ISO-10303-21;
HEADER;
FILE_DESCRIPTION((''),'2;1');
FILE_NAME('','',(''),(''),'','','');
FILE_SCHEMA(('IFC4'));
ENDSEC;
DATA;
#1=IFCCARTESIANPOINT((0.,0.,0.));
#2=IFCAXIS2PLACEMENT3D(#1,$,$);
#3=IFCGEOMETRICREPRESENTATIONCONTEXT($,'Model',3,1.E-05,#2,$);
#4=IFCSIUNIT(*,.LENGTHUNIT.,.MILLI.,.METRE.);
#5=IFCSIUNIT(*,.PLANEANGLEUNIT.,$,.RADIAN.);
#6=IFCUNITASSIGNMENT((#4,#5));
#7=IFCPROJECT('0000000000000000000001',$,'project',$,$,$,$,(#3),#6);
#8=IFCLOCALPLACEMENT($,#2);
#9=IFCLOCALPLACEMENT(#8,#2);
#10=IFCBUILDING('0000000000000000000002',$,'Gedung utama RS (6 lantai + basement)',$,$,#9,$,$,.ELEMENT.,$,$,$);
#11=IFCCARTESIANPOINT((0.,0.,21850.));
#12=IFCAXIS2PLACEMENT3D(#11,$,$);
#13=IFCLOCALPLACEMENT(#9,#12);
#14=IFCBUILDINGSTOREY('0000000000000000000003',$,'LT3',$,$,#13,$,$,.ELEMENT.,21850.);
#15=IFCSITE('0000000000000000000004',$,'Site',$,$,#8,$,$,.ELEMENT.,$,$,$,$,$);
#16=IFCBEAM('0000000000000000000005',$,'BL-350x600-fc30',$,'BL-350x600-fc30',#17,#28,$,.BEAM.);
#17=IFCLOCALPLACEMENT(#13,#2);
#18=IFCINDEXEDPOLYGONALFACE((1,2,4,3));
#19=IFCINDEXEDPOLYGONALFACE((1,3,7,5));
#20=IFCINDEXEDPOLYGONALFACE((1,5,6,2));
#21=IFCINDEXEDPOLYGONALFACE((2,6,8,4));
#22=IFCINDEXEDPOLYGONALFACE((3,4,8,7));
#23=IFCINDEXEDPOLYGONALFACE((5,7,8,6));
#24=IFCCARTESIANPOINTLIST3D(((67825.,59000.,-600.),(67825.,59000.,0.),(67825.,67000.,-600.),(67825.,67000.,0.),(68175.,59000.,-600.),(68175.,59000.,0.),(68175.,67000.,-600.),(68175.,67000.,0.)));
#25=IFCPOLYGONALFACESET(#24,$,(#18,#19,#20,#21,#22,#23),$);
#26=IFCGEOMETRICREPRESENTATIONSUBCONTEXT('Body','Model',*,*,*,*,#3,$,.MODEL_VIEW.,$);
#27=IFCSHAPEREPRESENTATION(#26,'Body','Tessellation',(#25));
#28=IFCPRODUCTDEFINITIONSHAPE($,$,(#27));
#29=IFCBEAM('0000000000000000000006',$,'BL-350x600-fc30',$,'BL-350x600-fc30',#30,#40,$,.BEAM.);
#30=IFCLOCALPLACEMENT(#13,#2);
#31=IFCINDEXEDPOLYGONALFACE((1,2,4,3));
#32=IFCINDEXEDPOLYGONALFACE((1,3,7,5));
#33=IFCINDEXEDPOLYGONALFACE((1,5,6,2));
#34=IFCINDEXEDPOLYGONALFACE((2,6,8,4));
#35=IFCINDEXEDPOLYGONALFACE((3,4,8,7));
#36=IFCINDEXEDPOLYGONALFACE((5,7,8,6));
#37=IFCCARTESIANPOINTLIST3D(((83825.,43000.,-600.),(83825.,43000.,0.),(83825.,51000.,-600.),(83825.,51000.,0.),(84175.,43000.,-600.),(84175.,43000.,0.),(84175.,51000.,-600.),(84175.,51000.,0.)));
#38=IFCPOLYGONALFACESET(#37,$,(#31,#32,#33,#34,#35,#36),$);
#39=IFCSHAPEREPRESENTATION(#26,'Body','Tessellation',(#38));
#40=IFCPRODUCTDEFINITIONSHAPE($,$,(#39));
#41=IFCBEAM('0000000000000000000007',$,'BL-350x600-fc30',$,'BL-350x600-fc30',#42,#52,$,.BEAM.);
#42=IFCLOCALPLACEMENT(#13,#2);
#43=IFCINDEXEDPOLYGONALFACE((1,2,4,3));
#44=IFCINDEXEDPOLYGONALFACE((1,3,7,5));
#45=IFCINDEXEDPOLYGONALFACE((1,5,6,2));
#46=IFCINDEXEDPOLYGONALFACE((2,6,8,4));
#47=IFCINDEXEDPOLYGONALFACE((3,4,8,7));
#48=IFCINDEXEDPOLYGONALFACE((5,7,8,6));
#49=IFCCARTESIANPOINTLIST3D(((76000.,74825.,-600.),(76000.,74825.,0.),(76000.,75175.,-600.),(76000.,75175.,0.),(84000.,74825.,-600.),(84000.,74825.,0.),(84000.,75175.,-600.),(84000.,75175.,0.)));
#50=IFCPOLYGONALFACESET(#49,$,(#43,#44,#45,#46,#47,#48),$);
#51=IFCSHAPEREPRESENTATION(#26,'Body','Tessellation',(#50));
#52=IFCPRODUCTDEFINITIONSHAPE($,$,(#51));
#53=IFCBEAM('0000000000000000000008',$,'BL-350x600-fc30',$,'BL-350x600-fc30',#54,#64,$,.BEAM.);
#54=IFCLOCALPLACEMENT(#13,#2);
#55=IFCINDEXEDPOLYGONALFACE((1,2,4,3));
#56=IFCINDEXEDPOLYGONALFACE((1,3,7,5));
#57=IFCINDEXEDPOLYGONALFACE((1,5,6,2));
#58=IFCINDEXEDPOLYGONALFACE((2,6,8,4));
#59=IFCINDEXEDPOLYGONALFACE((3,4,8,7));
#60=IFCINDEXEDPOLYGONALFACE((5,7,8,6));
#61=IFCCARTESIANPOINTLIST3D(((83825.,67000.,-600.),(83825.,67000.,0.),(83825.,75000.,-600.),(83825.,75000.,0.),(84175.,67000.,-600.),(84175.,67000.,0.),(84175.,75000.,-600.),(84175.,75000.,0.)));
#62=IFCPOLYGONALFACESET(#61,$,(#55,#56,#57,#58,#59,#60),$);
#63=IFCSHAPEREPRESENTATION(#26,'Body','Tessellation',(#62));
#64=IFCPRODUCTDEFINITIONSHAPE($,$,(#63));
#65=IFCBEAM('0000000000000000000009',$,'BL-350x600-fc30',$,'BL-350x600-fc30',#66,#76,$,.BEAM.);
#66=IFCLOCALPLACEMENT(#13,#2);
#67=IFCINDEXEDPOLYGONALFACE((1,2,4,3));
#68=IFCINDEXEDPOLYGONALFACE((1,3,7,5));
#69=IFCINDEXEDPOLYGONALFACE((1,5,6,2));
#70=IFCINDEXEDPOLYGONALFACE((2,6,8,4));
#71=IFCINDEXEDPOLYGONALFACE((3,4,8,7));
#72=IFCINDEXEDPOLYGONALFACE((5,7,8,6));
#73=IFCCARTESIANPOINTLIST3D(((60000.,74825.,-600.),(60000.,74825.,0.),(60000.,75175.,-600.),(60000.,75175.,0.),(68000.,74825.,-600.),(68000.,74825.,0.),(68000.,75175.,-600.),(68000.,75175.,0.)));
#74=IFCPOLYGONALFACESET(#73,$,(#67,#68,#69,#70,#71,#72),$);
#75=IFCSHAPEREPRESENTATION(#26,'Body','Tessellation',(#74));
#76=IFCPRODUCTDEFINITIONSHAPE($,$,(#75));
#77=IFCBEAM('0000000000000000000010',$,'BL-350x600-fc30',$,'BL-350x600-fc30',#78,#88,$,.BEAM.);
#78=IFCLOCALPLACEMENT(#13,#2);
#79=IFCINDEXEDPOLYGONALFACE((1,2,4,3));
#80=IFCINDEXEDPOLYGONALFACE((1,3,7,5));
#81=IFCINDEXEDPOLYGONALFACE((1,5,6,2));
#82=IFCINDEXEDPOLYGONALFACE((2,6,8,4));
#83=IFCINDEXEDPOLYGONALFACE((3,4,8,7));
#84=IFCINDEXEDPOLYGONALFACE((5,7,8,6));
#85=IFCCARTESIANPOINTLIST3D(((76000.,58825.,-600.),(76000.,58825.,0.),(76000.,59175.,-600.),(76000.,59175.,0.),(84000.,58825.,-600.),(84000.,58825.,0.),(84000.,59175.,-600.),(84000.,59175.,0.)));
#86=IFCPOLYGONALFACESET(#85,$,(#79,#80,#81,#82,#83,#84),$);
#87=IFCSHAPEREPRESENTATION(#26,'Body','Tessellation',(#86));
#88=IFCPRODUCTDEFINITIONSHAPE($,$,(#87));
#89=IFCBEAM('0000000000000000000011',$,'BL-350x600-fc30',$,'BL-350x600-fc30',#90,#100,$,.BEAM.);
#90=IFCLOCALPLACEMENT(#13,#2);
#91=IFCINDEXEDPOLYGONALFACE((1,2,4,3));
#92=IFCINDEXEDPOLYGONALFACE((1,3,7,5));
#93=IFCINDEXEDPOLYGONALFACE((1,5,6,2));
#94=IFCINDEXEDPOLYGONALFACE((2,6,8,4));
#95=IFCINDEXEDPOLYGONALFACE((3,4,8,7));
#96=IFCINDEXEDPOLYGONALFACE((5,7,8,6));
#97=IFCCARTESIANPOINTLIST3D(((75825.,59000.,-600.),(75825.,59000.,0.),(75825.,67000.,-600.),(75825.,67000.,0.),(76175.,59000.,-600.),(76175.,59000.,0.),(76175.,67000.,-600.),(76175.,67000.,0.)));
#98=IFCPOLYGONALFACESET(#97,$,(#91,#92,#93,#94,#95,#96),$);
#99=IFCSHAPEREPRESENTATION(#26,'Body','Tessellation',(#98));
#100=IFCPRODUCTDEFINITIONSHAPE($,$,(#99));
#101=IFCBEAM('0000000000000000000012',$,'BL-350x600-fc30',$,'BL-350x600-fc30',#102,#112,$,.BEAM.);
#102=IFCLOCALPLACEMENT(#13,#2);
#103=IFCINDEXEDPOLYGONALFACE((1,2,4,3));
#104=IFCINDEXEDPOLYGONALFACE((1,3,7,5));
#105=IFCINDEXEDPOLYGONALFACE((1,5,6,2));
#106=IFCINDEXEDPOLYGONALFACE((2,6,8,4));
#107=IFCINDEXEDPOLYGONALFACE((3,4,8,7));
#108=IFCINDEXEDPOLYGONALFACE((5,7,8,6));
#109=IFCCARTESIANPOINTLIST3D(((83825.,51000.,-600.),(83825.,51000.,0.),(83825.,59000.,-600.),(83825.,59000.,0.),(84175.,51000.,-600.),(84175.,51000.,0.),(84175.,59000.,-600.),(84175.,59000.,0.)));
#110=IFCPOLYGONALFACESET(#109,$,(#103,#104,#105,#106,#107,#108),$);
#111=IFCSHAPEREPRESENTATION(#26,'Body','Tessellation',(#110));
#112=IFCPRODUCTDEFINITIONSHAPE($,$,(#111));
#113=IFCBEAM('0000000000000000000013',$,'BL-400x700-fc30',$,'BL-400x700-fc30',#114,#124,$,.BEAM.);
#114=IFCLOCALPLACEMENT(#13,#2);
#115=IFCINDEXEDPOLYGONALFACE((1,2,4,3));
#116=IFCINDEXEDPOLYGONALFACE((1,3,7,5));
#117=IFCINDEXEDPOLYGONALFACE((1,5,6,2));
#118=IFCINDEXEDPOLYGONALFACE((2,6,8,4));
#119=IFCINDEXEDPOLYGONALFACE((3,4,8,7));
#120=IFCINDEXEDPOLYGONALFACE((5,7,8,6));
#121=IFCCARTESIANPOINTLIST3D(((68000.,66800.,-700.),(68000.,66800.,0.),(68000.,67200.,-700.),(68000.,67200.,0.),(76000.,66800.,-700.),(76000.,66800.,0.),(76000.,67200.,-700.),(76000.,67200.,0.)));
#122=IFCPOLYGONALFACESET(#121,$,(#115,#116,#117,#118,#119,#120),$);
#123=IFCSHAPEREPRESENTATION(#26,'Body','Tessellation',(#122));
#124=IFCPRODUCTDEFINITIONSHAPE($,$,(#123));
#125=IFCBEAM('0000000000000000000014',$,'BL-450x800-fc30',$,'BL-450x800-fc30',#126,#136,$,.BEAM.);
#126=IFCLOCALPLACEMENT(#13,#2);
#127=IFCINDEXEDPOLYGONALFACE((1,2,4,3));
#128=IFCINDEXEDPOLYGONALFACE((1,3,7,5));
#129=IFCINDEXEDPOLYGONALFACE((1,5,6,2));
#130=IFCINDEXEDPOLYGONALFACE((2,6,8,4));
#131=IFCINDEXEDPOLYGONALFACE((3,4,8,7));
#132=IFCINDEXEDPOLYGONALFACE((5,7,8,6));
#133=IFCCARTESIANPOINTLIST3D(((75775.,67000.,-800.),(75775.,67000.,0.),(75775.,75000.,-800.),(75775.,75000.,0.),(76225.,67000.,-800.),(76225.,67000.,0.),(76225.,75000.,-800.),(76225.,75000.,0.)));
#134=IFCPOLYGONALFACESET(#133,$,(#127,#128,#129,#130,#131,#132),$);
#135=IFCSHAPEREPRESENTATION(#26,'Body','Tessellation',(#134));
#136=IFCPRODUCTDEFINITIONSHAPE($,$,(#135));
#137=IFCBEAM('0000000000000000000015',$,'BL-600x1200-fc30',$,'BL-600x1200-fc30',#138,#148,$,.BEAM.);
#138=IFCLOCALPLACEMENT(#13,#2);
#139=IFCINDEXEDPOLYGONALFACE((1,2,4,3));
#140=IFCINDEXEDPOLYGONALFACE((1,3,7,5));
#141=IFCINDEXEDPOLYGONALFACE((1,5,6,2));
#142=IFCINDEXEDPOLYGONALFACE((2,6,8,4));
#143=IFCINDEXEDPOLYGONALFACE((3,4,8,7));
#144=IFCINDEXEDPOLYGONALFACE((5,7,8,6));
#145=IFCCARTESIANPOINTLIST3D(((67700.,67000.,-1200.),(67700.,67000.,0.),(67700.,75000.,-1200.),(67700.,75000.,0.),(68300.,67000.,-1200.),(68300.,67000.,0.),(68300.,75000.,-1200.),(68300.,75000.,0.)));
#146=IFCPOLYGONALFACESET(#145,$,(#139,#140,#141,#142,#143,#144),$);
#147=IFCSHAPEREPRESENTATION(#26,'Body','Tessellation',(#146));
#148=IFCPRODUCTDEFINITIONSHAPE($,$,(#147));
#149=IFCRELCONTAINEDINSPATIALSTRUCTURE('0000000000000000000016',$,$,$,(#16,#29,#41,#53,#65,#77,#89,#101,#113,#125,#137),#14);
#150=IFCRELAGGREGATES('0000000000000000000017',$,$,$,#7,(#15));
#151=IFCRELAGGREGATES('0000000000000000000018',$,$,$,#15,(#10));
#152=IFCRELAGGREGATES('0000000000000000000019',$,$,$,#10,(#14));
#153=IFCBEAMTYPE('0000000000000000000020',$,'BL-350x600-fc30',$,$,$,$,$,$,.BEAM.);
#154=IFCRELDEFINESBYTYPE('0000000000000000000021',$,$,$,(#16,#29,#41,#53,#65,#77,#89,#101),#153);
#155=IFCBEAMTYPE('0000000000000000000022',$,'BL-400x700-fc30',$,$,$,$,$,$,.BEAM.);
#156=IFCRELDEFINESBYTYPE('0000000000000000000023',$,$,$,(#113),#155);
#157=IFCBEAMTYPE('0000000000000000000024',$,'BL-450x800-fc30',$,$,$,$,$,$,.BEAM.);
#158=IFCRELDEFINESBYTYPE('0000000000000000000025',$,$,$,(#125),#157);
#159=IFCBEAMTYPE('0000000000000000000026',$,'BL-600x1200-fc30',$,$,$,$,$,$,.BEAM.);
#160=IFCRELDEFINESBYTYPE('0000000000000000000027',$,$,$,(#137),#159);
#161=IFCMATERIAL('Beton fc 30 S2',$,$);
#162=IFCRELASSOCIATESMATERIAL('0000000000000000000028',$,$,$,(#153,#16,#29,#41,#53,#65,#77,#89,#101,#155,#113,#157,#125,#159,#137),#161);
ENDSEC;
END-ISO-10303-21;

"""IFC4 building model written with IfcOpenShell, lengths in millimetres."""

from ifc_helpers import new_model, si_unit, frame, origin, origin_2d, place, context, subcontext, project, spatial, rectangle, extrude, material, material_profile, profile_set, profile_usage, type_object, element, save


model = new_model("IFC4")

# Units and contexts
model_context = context("Model", 3, precision=1e-05, world=origin())
body_context = subcontext(model_context, "Body", "Model", "MODEL_VIEW")
ifc_project = project(units=[si_unit("LENGTHUNIT", "METRE", prefix="MILLI"), si_unit("PLANEANGLEUNIT", "RADIAN")], contexts=[model_context])

# Site, building, storey
site_placement = place(None, origin())
site = spatial("IfcSite", under=ifc_project, at=site_placement, Name="Site", CompositionType="ELEMENT")
building_placement = place(site_placement, origin())
building = spatial("IfcBuilding", under=site, at=building_placement, Name="Gedung utama RS (6 lantai + basement)", CompositionType="ELEMENT")
storey_placement = place(building_placement, frame((0.0, 0.0, 21850.0)))
storey = spatial("IfcBuildingStorey", under=building, at=storey_placement, Name="LT3", CompositionType="ELEMENT", Elevation=21850.0)

# Beams
ifc_material = material(Name="Beton fc 30 S2")
ifc_material_profile_1 = material_profile(ifc_material, rectangle(XDim=350.0, YDim=600.0, at=origin_2d()), Name="BL-350x600-fc30")
ifc_profile_set_1 = profile_set([ifc_material_profile_1], Name="BL-350x600-fc30")
ifc_profile_usage_1 = profile_usage(ifc_profile_set_1, cardinal=8)
beam_type_1 = type_object("IfcBeamType", Name="BL-350x600-fc30", PredefinedType="BEAM", material=ifc_profile_set_1)
for number, where, name in (
    (1, (68000.0, 59000.0, -300.0), "BL-350x600-fc30"),
    (2, (84000.0, 43000.0, -300.0), "BL-350x600-fc30"),
):
    element("IfcBeam", number, at=place(storey_placement, frame(where)), inside=storey, type_object=beam_type_1, material=ifc_profile_usage_1, Name=name, ObjectType="BL-350x600-fc30", PredefinedType="BEAM", context=body_context, shape_type="SweptSolid", body=[
        extrude(rectangle(XDim=350.0, YDim=600.0, at=origin_2d()), frame((0.0, 0.0, 0.0), z_axis=(0.0, 1.0, 0.0), x_axis=(-1.0, 0.0, 0.0)), (0.0, 0.0, 1.0), 8000.0),
    ])
beam_1_placement = place(storey_placement, frame((76000.0, 75000.0, -300.0)))
element("IfcBeam", 3, at=beam_1_placement, inside=storey, type_object=beam_type_1, material=ifc_profile_usage_1, Name="BL-350x600-fc30", ObjectType="BL-350x600-fc30", PredefinedType="BEAM", context=body_context, shape_type="SweptSolid", body=[
    extrude(rectangle(XDim=350.0, YDim=600.0, at=origin_2d()), frame((0.0, 0.0, 0.0), z_axis=(1.0, 0.0, 0.0), x_axis=(0.0, 1.0, 0.0)), (0.0, 0.0, 1.0), 8000.0),
])
beam_2_placement = place(storey_placement, frame((84000.0, 67000.0, -300.0)))
element("IfcBeam", 4, at=beam_2_placement, inside=storey, type_object=beam_type_1, material=ifc_profile_usage_1, Name="BL-350x600-fc30", ObjectType="BL-350x600-fc30", PredefinedType="BEAM", context=body_context, shape_type="SweptSolid", body=[
    extrude(rectangle(XDim=350.0, YDim=600.0, at=origin_2d()), frame((0.0, 0.0, 0.0), z_axis=(0.0, 1.0, 0.0), x_axis=(-1.0, 0.0, 0.0)), (0.0, 0.0, 1.0), 8000.0),
])
for number, where, name in (
    (5, (60000.0, 75000.0, -300.0), "BL-350x600-fc30"),
    (6, (76000.0, 59000.0, -300.0), "BL-350x600-fc30"),
):
    element("IfcBeam", number, at=place(storey_placement, frame(where)), inside=storey, type_object=beam_type_1, material=ifc_profile_usage_1, Name=name, ObjectType="BL-350x600-fc30", PredefinedType="BEAM", context=body_context, shape_type="SweptSolid", body=[
        extrude(rectangle(XDim=350.0, YDim=600.0, at=origin_2d()), frame((0.0, 0.0, 0.0), z_axis=(1.0, 0.0, 0.0), x_axis=(0.0, 1.0, 0.0)), (0.0, 0.0, 1.0), 8000.0),
    ])
for number, where, name in (
    (7, (76000.0, 59000.0, -300.0), "BL-350x600-fc30"),
    (8, (84000.0, 51000.0, -300.0), "BL-350x600-fc30"),
):
    element("IfcBeam", number, at=place(storey_placement, frame(where)), inside=storey, type_object=beam_type_1, material=ifc_profile_usage_1, Name=name, ObjectType="BL-350x600-fc30", PredefinedType="BEAM", context=body_context, shape_type="SweptSolid", body=[
        extrude(rectangle(XDim=350.0, YDim=600.0, at=origin_2d()), frame((0.0, 0.0, 0.0), z_axis=(0.0, 1.0, 0.0), x_axis=(-1.0, 0.0, 0.0)), (0.0, 0.0, 1.0), 8000.0),
    ])
ifc_material_profile_2 = material_profile(ifc_material, rectangle(XDim=400.0, YDim=700.0, at=origin_2d()), Name="BL-400x700-fc30")
ifc_profile_set_2 = profile_set([ifc_material_profile_2], Name="BL-400x700-fc30")
ifc_profile_usage_2 = profile_usage(ifc_profile_set_2, cardinal=8)
beam_type_2 = type_object("IfcBeamType", Name="BL-400x700-fc30", PredefinedType="BEAM", material=ifc_profile_set_2)
beam_3_placement = place(storey_placement, frame((68000.0, 67000.0, -350.0)))
element("IfcBeam", 9, at=beam_3_placement, inside=storey, type_object=beam_type_2, material=ifc_profile_usage_2, Name="BL-400x700-fc30", ObjectType="BL-400x700-fc30", PredefinedType="BEAM", context=body_context, shape_type="SweptSolid", body=[
    extrude(rectangle(XDim=400.0, YDim=700.0, at=origin_2d()), frame((0.0, 0.0, 0.0), z_axis=(1.0, 0.0, 0.0), x_axis=(0.0, 1.0, 0.0)), (0.0, 0.0, 1.0), 8000.0),
])
ifc_material_profile_3 = material_profile(ifc_material, rectangle(XDim=450.0, YDim=800.0, at=origin_2d()), Name="BL-450x800-fc30")
ifc_profile_set_3 = profile_set([ifc_material_profile_3], Name="BL-450x800-fc30")
ifc_profile_usage_3 = profile_usage(ifc_profile_set_3, cardinal=8)
beam_type_3 = type_object("IfcBeamType", Name="BL-450x800-fc30", PredefinedType="BEAM", material=ifc_profile_set_3)
beam_4_placement = place(storey_placement, frame((76000.0, 67000.0, -400.0)))
element("IfcBeam", 10, at=beam_4_placement, inside=storey, type_object=beam_type_3, material=ifc_profile_usage_3, Name="BL-450x800-fc30", ObjectType="BL-450x800-fc30", PredefinedType="BEAM", context=body_context, shape_type="SweptSolid", body=[
    extrude(rectangle(XDim=450.0, YDim=800.0, at=origin_2d()), frame((0.0, 0.0, 0.0), z_axis=(0.0, 1.0, 0.0), x_axis=(-1.0, 0.0, 0.0)), (0.0, 0.0, 1.0), 8000.0),
])
ifc_material_profile_4 = material_profile(ifc_material, rectangle(XDim=600.0, YDim=1200.0, at=origin_2d()), Name="BL-600x1200-fc30")
ifc_profile_set_4 = profile_set([ifc_material_profile_4], Name="BL-600x1200-fc30")
ifc_profile_usage_4 = profile_usage(ifc_profile_set_4, cardinal=8)
beam_type_4 = type_object("IfcBeamType", Name="BL-600x1200-fc30", PredefinedType="BEAM", material=ifc_profile_set_4)
beam_5_placement = place(storey_placement, frame((68000.0, 67000.0, -600.0)))
element("IfcBeam", 11, at=beam_5_placement, inside=storey, type_object=beam_type_4, material=ifc_profile_usage_4, Name="BL-600x1200-fc30", ObjectType="BL-600x1200-fc30", PredefinedType="BEAM", context=body_context, shape_type="SweptSolid", body=[
    extrude(rectangle(XDim=600.0, YDim=1200.0, at=origin_2d()), frame((0.0, 0.0, 0.0), z_axis=(0.0, 1.0, 0.0), x_axis=(-1.0, 0.0, 0.0)), (0.0, 0.0, 1.0), 8000.0),
])

save(model, "model.ifc")
